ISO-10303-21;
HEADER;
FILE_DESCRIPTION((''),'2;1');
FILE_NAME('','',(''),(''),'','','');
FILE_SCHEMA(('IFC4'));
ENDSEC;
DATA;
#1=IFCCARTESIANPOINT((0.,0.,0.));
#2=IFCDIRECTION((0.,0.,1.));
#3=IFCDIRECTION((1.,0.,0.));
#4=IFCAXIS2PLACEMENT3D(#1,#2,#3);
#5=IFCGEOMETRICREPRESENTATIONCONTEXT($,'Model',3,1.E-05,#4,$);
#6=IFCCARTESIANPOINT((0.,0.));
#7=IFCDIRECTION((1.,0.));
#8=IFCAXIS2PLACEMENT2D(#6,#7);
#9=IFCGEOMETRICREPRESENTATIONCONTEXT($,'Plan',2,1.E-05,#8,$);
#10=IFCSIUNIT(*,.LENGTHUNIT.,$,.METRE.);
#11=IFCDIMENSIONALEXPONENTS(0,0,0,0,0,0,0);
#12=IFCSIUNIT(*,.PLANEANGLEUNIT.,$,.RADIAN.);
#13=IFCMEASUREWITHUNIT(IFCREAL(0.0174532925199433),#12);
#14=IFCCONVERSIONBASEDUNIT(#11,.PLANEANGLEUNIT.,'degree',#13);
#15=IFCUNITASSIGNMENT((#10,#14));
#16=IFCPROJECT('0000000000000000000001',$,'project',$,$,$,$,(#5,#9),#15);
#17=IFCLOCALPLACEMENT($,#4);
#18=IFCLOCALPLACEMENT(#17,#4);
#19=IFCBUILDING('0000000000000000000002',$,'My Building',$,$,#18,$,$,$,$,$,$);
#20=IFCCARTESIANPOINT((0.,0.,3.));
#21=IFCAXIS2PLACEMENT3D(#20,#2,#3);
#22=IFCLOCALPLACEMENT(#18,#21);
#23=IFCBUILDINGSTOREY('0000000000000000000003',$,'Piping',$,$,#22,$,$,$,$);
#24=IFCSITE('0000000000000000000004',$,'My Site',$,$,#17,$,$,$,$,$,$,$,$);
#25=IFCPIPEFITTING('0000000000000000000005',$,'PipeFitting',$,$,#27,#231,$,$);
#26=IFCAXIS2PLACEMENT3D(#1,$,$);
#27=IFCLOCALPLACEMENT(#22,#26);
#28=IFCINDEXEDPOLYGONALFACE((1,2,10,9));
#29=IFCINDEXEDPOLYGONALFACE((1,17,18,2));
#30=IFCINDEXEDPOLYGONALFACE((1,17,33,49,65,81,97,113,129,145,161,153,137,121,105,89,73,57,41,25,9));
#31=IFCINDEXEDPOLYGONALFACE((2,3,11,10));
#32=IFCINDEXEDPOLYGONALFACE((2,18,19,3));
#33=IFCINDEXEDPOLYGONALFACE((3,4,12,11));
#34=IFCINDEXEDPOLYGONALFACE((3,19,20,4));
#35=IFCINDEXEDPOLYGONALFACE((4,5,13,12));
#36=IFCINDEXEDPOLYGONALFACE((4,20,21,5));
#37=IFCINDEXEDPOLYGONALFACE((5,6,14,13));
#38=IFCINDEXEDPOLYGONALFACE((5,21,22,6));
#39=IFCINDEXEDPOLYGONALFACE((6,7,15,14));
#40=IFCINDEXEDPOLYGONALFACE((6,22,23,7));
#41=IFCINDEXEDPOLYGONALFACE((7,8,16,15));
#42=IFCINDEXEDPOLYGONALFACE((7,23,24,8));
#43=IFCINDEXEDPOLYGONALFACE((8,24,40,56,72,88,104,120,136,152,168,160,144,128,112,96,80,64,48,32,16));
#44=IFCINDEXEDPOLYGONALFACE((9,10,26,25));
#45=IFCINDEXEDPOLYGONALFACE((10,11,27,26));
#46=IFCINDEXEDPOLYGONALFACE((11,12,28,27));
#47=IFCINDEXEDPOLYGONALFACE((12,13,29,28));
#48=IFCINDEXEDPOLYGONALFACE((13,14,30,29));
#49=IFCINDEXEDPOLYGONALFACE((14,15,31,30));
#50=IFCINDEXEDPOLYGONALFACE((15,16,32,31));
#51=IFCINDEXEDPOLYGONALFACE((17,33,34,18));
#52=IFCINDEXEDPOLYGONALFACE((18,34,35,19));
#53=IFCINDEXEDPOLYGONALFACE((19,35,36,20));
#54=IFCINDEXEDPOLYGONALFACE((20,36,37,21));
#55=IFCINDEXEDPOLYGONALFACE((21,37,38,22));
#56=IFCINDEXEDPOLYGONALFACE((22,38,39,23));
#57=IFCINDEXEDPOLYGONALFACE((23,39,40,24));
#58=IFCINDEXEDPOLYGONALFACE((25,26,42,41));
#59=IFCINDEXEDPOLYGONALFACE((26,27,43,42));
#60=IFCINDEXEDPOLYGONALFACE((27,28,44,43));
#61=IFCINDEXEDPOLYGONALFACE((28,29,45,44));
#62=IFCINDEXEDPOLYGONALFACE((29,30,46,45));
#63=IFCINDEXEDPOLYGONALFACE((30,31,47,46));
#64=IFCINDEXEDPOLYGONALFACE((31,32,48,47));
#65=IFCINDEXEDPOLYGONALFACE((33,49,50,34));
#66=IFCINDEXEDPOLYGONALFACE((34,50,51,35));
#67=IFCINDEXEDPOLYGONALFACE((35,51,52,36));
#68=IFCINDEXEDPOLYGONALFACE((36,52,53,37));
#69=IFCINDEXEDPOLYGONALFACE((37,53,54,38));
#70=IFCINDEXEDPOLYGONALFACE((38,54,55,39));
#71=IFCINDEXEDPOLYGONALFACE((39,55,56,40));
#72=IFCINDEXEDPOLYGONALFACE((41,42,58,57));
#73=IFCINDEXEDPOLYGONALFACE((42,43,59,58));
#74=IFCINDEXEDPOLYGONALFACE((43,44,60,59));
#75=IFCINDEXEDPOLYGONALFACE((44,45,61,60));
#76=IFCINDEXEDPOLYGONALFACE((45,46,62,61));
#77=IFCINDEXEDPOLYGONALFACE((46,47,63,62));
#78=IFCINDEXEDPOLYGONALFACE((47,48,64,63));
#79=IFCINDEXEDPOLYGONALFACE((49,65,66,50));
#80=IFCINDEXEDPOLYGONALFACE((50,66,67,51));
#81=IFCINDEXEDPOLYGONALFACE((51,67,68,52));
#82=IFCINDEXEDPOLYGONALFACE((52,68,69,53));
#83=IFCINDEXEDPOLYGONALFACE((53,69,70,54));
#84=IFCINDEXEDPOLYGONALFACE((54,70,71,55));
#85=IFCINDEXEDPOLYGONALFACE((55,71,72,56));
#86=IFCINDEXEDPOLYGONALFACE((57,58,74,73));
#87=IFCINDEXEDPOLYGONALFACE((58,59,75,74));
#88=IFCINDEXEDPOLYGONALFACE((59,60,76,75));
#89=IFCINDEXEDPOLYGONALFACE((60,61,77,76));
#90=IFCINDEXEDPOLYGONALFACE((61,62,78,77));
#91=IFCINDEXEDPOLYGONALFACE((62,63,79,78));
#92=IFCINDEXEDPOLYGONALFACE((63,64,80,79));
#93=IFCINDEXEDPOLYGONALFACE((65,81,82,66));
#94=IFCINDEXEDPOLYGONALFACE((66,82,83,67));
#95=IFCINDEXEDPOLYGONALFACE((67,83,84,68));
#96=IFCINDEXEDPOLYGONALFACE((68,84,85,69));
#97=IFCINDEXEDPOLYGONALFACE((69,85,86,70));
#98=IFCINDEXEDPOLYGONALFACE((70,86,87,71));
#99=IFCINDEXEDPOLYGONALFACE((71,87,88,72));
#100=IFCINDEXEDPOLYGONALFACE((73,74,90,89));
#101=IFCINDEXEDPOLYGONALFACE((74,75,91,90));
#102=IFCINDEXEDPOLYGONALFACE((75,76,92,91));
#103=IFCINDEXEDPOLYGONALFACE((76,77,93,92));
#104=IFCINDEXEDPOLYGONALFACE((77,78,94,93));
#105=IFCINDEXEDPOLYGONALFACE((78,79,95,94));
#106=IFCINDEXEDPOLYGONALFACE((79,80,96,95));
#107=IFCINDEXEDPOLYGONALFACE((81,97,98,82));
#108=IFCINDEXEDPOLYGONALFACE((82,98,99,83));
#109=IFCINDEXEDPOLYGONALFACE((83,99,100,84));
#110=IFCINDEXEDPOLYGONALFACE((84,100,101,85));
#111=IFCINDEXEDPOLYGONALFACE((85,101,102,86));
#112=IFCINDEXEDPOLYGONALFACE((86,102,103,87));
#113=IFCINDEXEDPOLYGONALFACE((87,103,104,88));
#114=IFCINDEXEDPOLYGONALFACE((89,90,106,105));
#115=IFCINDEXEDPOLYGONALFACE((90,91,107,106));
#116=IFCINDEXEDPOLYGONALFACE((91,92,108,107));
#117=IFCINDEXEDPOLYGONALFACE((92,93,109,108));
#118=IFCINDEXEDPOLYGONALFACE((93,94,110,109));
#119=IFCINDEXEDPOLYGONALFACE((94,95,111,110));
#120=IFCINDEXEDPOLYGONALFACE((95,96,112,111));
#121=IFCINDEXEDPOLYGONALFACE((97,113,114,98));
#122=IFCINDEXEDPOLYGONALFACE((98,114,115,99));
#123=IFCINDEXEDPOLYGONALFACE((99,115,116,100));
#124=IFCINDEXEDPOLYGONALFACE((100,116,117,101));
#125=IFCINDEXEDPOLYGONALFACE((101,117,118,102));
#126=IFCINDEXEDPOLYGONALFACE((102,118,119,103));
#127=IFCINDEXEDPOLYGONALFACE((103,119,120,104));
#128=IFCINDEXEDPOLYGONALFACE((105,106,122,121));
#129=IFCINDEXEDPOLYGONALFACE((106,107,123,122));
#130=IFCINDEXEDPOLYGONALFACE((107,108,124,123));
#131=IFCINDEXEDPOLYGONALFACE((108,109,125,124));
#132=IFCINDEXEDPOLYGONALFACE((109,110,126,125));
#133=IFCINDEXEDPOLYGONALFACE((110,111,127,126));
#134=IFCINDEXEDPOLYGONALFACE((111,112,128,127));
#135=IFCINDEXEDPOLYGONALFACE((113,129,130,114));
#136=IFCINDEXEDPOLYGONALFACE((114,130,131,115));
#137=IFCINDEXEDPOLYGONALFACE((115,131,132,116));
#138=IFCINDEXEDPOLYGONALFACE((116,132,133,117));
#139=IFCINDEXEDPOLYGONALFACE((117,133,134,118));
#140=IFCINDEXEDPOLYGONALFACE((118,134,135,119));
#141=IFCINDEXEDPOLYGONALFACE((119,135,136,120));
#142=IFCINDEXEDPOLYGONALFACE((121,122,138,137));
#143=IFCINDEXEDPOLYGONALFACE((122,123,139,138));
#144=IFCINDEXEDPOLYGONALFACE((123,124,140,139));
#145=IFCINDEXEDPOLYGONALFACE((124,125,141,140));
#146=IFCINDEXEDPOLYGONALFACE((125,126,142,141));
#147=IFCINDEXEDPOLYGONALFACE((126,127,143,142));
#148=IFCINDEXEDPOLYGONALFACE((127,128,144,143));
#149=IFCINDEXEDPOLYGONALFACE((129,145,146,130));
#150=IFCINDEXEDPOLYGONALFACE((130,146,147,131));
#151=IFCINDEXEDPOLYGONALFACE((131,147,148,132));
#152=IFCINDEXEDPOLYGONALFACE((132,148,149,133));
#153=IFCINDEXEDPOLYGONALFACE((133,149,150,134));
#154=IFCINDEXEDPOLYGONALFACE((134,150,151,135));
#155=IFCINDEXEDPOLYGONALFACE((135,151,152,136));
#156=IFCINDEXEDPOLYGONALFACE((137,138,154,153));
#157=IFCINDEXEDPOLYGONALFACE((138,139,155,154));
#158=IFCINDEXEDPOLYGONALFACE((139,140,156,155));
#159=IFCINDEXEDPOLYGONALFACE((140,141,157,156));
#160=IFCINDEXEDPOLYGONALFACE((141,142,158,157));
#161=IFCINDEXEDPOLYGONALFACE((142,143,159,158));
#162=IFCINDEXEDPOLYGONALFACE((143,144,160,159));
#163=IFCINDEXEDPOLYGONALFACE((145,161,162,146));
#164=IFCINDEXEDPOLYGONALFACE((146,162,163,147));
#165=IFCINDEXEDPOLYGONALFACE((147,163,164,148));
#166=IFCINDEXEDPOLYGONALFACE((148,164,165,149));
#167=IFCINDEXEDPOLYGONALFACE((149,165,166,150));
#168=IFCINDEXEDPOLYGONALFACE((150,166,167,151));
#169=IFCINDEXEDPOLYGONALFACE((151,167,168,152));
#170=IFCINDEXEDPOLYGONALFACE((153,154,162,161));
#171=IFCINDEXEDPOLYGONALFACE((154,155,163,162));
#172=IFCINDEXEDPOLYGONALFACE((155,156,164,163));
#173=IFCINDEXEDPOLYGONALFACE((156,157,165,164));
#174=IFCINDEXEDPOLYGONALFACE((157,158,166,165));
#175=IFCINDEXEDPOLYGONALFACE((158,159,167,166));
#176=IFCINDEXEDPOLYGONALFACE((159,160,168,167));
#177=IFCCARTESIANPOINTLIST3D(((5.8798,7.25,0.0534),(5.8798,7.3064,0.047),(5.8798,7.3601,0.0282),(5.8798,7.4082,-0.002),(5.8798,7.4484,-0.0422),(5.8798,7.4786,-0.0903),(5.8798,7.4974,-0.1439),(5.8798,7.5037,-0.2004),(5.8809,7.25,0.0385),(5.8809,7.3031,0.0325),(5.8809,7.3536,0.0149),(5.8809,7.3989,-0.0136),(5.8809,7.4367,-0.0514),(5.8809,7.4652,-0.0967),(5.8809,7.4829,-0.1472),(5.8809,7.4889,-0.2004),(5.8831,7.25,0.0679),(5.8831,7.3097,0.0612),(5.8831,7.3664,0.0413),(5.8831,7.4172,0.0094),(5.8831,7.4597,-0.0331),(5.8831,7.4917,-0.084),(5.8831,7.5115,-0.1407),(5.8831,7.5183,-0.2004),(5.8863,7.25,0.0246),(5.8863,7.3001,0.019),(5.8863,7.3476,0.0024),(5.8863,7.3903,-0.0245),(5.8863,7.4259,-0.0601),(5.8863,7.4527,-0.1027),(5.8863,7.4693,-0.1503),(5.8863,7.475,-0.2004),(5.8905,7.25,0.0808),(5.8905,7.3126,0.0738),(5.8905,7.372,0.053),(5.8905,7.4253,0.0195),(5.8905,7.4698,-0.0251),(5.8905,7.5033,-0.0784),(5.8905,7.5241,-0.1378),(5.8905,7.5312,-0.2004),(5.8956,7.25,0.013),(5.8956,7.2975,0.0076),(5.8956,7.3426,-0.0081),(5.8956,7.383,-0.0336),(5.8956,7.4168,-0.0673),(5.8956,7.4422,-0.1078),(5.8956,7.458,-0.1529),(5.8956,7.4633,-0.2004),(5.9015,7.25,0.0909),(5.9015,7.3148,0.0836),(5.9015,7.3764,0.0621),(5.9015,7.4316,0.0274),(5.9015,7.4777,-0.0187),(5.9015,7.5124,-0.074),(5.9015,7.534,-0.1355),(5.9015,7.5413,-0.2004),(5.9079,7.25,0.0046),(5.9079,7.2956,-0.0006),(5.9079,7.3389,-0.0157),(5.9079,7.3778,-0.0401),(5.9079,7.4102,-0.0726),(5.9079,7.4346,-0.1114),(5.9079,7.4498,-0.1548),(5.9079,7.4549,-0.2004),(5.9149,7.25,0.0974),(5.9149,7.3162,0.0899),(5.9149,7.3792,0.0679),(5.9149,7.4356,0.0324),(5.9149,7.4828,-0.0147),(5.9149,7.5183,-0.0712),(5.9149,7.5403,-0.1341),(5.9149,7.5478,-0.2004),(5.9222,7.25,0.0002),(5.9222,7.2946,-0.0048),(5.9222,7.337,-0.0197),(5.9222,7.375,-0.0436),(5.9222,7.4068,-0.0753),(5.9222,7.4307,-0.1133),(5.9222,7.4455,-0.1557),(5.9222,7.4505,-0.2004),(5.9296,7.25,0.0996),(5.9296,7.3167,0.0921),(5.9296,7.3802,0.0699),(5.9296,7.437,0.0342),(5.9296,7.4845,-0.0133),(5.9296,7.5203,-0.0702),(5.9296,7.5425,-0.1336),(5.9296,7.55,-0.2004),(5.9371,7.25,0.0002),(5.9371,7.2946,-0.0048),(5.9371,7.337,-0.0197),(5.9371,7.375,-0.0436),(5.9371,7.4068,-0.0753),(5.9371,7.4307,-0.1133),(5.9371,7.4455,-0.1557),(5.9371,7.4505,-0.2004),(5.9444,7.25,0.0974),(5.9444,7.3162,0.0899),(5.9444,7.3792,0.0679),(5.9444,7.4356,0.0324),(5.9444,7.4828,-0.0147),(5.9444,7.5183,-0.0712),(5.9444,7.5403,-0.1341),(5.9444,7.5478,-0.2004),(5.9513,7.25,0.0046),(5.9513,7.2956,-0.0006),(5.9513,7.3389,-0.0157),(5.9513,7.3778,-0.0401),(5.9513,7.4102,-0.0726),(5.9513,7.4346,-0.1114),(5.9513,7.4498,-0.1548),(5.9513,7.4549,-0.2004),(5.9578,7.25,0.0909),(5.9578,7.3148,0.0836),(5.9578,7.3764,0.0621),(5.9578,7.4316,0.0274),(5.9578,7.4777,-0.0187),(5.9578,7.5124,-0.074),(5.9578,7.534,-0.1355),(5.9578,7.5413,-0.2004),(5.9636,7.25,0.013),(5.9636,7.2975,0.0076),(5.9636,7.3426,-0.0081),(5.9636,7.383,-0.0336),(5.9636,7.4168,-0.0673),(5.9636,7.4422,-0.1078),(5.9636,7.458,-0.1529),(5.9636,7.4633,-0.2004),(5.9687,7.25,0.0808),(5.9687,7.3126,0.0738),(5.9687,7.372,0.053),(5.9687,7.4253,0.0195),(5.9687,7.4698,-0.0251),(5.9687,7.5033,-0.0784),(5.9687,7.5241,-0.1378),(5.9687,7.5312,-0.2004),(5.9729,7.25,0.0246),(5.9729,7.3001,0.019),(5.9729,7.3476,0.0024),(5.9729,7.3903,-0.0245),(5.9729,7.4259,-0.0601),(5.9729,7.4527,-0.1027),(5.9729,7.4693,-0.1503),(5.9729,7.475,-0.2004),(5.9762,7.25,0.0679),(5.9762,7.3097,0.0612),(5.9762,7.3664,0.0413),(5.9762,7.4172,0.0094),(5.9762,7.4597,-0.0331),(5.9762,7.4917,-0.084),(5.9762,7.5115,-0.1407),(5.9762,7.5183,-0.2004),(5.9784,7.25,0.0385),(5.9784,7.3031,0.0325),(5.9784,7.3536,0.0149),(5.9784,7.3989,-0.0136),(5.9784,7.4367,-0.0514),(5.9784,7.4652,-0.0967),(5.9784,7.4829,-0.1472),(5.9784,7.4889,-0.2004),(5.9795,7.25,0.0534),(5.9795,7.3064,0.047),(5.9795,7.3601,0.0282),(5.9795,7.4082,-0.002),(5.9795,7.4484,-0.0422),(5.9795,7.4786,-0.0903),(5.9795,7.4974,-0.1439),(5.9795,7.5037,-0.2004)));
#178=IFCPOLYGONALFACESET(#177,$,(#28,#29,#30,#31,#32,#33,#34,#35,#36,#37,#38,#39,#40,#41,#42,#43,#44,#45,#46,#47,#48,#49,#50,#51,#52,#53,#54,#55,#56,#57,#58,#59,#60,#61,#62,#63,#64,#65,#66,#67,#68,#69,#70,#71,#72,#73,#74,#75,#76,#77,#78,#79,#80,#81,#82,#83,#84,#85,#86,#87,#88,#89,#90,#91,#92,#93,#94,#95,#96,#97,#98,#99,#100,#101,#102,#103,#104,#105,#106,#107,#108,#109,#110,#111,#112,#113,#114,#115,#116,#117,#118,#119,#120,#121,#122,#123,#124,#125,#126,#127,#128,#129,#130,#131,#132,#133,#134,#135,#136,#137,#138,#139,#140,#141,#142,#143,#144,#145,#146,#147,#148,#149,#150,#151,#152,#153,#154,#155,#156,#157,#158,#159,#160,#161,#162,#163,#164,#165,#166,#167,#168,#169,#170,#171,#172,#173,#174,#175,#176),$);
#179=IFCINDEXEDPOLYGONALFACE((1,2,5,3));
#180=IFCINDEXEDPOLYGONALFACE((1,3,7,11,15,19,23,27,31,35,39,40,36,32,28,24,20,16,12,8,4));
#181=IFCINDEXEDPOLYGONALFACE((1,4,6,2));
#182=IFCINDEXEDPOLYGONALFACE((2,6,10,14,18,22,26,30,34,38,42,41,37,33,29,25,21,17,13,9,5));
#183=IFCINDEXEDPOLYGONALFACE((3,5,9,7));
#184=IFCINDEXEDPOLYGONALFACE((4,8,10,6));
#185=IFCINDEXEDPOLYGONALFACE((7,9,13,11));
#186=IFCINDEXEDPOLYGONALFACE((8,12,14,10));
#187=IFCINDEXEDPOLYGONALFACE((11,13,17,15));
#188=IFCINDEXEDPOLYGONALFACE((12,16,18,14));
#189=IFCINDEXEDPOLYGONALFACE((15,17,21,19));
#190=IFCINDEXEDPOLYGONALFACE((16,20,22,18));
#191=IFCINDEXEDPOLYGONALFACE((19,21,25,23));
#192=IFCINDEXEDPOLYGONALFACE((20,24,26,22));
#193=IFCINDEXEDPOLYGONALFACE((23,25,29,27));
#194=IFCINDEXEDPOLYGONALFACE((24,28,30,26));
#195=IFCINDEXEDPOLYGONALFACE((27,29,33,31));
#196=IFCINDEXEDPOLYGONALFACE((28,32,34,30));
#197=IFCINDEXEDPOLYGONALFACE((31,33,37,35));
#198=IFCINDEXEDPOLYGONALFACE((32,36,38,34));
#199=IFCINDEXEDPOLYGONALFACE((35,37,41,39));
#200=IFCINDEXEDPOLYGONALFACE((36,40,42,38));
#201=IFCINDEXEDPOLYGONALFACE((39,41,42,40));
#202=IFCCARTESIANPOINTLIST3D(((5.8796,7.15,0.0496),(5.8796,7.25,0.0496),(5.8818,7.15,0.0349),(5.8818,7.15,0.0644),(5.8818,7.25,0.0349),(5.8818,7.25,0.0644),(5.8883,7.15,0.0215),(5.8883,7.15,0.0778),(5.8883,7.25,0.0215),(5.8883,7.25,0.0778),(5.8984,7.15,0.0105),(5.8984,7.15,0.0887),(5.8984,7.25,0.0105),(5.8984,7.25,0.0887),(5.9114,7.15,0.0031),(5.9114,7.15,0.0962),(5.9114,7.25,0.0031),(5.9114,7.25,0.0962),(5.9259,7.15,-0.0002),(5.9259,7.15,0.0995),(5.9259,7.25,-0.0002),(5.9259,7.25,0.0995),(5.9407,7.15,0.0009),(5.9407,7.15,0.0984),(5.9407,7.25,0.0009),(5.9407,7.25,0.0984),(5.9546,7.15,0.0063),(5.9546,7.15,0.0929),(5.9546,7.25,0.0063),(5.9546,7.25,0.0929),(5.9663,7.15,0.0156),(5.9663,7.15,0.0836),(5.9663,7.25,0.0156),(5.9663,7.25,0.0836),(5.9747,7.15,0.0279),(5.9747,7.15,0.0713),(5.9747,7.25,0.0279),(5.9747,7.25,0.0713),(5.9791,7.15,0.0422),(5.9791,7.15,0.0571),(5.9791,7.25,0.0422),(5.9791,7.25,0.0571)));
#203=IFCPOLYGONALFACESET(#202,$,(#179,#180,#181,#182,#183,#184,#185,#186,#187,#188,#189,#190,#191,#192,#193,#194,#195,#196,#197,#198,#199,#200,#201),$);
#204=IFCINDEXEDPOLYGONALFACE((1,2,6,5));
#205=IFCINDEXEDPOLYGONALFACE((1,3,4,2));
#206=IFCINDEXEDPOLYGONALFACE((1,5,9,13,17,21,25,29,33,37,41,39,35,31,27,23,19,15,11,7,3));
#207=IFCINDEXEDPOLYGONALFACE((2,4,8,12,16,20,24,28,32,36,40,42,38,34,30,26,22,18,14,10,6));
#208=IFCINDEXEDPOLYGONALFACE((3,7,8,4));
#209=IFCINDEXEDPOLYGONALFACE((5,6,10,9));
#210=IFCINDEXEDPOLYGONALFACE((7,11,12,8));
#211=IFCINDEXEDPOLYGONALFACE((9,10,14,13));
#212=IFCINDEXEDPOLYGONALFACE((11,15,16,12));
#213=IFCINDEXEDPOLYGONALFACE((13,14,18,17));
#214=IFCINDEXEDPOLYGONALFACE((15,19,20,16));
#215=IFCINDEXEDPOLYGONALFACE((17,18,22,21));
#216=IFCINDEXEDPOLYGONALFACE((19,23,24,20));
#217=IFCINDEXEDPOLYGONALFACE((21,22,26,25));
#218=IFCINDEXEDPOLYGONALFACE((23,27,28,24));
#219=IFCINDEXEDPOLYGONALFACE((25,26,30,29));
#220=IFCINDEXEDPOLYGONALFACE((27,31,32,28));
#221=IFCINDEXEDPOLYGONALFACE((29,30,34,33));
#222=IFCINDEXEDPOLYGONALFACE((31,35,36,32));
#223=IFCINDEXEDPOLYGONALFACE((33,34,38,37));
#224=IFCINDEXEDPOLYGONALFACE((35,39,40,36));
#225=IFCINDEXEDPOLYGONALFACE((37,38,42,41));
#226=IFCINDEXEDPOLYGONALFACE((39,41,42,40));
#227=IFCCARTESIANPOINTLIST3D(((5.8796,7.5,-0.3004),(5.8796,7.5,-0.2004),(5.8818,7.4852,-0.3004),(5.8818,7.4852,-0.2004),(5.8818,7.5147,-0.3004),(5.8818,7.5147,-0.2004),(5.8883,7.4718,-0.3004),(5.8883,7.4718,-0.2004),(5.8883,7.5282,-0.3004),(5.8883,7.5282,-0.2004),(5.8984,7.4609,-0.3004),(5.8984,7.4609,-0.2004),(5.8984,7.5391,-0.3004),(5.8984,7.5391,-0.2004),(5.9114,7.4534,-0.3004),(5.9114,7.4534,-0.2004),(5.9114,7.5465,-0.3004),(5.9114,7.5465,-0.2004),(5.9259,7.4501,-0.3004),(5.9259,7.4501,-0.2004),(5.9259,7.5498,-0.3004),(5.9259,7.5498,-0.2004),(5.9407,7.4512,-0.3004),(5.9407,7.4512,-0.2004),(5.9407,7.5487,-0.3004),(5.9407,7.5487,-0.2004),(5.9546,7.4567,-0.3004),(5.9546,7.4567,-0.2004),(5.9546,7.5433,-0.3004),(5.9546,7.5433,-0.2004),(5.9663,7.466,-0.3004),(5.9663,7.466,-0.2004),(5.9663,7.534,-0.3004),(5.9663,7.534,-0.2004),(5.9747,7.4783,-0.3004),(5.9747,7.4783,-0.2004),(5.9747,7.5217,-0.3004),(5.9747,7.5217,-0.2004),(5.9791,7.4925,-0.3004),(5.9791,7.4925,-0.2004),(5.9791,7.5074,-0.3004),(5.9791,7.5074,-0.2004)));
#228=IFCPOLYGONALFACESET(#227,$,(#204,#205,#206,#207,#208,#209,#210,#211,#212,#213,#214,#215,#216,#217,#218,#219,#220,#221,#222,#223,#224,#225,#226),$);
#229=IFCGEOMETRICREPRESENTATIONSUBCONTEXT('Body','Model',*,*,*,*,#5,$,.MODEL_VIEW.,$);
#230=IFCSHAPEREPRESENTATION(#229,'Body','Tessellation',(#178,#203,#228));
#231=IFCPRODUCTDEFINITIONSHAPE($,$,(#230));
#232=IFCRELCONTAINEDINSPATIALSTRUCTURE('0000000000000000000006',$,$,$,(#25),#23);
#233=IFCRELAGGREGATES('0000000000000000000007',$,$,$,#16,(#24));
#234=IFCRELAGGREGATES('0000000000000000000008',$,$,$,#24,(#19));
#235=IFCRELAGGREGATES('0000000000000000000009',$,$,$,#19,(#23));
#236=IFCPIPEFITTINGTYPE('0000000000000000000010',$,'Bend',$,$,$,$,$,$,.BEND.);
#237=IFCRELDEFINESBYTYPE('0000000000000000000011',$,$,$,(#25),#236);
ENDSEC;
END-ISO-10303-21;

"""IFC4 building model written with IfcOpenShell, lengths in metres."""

from ifc_helpers import new_model, entity, si_unit, converted_unit, frame, origin_with_axes, origin_2d_with_axis, place, context, subcontext, project, spatial, circle, extrude, source, transform, mapped, type_object, type_shapes, element, save


model = new_model("IFC4")

# Units and contexts
model_context = context("Model", 3, precision=1e-05, world=origin_with_axes())
plan_context = context("Plan", 2, precision=1e-05, world=origin_2d_with_axis())
body_context = subcontext(model_context, "Body", "Model", "MODEL_VIEW")
ifc_project = project(units=[si_unit("LENGTHUNIT", "METRE"), converted_unit("PLANEANGLEUNIT", "degree", entity("IfcReal", 0.0174532925199433), si_unit("PLANEANGLEUNIT", "RADIAN"), dimensions=[0, 0, 0, 0, 0, 0, 0])], contexts=[model_context, plan_context])

# Site, building, storey
site_placement = place(None, origin_with_axes())
site = spatial("IfcSite", under=ifc_project, at=site_placement, Name="My Site")
building_placement = place(site_placement, origin_with_axes())
building = spatial("IfcBuilding", under=site, at=building_placement, Name="My Building")
storey_placement = place(building_placement, frame((0.0, 0.0, 3.0), z_axis=(0.0, 0.0, 1.0), x_axis=(1.0, 0.0, 0.0)))
storey = spatial("IfcBuildingStorey", under=building, at=storey_placement, Name="Piping")

# Pipe fitting
pipe_fitting_type_1 = type_object("IfcPipeFittingType", Name="Bend", PredefinedType="BEND")
shared_shape = source(origin_with_axes(), body_context, "Body", "SolidModel", [
    entity("IfcSweptDiskSolid", entity("IfcIndexedPolyCurve", entity("IfcCartesianPointList3D", [[0.0, 0.0, 0.1], [0.0, -0.0732, 0.2768], [0.0, -0.25, 0.35]]), [entity("IfcArcIndex", [1, 2, 3])]), 0.05),
    extrude(circle(Radius=0.05), origin_with_axes(), (0.0, 0.0, 1.0), 0.1),
    extrude(circle(Radius=0.05), frame((0.0, -0.25, 0.35), z_axis=(0.0, -1.0, 0.0), x_axis=(1.0, 0.0, 0.0)), (0.0, 0.0, 1.0), 0.1),
])
type_shapes(pipe_fitting_type_1, [shared_shape])
for number, where, z_axis, x_axis, name in (
    (1, (5.9296, 7.15, 0.0496), (0.0, 1.0, 0.0), (-1.0, 0.0, 0.0), "PipeFitting"),
):
    element("IfcPipeFitting", number, at=place(storey_placement, frame(where, z_axis=z_axis, x_axis=x_axis)), inside=storey, type_object=pipe_fitting_type_1, Name=name, context=body_context, shape_type="MappedRepresentation", body=[
        mapped(shared_shape, transform((0.0, 0.0, 0.0), x_axis=(1.0, 0.0, 0.0), y_axis=(0.0, 1.0, 0.0), z_axis=(0.0, 0.0, 1.0), scale=1.0)),
    ])

save(model, "model.ifc")
